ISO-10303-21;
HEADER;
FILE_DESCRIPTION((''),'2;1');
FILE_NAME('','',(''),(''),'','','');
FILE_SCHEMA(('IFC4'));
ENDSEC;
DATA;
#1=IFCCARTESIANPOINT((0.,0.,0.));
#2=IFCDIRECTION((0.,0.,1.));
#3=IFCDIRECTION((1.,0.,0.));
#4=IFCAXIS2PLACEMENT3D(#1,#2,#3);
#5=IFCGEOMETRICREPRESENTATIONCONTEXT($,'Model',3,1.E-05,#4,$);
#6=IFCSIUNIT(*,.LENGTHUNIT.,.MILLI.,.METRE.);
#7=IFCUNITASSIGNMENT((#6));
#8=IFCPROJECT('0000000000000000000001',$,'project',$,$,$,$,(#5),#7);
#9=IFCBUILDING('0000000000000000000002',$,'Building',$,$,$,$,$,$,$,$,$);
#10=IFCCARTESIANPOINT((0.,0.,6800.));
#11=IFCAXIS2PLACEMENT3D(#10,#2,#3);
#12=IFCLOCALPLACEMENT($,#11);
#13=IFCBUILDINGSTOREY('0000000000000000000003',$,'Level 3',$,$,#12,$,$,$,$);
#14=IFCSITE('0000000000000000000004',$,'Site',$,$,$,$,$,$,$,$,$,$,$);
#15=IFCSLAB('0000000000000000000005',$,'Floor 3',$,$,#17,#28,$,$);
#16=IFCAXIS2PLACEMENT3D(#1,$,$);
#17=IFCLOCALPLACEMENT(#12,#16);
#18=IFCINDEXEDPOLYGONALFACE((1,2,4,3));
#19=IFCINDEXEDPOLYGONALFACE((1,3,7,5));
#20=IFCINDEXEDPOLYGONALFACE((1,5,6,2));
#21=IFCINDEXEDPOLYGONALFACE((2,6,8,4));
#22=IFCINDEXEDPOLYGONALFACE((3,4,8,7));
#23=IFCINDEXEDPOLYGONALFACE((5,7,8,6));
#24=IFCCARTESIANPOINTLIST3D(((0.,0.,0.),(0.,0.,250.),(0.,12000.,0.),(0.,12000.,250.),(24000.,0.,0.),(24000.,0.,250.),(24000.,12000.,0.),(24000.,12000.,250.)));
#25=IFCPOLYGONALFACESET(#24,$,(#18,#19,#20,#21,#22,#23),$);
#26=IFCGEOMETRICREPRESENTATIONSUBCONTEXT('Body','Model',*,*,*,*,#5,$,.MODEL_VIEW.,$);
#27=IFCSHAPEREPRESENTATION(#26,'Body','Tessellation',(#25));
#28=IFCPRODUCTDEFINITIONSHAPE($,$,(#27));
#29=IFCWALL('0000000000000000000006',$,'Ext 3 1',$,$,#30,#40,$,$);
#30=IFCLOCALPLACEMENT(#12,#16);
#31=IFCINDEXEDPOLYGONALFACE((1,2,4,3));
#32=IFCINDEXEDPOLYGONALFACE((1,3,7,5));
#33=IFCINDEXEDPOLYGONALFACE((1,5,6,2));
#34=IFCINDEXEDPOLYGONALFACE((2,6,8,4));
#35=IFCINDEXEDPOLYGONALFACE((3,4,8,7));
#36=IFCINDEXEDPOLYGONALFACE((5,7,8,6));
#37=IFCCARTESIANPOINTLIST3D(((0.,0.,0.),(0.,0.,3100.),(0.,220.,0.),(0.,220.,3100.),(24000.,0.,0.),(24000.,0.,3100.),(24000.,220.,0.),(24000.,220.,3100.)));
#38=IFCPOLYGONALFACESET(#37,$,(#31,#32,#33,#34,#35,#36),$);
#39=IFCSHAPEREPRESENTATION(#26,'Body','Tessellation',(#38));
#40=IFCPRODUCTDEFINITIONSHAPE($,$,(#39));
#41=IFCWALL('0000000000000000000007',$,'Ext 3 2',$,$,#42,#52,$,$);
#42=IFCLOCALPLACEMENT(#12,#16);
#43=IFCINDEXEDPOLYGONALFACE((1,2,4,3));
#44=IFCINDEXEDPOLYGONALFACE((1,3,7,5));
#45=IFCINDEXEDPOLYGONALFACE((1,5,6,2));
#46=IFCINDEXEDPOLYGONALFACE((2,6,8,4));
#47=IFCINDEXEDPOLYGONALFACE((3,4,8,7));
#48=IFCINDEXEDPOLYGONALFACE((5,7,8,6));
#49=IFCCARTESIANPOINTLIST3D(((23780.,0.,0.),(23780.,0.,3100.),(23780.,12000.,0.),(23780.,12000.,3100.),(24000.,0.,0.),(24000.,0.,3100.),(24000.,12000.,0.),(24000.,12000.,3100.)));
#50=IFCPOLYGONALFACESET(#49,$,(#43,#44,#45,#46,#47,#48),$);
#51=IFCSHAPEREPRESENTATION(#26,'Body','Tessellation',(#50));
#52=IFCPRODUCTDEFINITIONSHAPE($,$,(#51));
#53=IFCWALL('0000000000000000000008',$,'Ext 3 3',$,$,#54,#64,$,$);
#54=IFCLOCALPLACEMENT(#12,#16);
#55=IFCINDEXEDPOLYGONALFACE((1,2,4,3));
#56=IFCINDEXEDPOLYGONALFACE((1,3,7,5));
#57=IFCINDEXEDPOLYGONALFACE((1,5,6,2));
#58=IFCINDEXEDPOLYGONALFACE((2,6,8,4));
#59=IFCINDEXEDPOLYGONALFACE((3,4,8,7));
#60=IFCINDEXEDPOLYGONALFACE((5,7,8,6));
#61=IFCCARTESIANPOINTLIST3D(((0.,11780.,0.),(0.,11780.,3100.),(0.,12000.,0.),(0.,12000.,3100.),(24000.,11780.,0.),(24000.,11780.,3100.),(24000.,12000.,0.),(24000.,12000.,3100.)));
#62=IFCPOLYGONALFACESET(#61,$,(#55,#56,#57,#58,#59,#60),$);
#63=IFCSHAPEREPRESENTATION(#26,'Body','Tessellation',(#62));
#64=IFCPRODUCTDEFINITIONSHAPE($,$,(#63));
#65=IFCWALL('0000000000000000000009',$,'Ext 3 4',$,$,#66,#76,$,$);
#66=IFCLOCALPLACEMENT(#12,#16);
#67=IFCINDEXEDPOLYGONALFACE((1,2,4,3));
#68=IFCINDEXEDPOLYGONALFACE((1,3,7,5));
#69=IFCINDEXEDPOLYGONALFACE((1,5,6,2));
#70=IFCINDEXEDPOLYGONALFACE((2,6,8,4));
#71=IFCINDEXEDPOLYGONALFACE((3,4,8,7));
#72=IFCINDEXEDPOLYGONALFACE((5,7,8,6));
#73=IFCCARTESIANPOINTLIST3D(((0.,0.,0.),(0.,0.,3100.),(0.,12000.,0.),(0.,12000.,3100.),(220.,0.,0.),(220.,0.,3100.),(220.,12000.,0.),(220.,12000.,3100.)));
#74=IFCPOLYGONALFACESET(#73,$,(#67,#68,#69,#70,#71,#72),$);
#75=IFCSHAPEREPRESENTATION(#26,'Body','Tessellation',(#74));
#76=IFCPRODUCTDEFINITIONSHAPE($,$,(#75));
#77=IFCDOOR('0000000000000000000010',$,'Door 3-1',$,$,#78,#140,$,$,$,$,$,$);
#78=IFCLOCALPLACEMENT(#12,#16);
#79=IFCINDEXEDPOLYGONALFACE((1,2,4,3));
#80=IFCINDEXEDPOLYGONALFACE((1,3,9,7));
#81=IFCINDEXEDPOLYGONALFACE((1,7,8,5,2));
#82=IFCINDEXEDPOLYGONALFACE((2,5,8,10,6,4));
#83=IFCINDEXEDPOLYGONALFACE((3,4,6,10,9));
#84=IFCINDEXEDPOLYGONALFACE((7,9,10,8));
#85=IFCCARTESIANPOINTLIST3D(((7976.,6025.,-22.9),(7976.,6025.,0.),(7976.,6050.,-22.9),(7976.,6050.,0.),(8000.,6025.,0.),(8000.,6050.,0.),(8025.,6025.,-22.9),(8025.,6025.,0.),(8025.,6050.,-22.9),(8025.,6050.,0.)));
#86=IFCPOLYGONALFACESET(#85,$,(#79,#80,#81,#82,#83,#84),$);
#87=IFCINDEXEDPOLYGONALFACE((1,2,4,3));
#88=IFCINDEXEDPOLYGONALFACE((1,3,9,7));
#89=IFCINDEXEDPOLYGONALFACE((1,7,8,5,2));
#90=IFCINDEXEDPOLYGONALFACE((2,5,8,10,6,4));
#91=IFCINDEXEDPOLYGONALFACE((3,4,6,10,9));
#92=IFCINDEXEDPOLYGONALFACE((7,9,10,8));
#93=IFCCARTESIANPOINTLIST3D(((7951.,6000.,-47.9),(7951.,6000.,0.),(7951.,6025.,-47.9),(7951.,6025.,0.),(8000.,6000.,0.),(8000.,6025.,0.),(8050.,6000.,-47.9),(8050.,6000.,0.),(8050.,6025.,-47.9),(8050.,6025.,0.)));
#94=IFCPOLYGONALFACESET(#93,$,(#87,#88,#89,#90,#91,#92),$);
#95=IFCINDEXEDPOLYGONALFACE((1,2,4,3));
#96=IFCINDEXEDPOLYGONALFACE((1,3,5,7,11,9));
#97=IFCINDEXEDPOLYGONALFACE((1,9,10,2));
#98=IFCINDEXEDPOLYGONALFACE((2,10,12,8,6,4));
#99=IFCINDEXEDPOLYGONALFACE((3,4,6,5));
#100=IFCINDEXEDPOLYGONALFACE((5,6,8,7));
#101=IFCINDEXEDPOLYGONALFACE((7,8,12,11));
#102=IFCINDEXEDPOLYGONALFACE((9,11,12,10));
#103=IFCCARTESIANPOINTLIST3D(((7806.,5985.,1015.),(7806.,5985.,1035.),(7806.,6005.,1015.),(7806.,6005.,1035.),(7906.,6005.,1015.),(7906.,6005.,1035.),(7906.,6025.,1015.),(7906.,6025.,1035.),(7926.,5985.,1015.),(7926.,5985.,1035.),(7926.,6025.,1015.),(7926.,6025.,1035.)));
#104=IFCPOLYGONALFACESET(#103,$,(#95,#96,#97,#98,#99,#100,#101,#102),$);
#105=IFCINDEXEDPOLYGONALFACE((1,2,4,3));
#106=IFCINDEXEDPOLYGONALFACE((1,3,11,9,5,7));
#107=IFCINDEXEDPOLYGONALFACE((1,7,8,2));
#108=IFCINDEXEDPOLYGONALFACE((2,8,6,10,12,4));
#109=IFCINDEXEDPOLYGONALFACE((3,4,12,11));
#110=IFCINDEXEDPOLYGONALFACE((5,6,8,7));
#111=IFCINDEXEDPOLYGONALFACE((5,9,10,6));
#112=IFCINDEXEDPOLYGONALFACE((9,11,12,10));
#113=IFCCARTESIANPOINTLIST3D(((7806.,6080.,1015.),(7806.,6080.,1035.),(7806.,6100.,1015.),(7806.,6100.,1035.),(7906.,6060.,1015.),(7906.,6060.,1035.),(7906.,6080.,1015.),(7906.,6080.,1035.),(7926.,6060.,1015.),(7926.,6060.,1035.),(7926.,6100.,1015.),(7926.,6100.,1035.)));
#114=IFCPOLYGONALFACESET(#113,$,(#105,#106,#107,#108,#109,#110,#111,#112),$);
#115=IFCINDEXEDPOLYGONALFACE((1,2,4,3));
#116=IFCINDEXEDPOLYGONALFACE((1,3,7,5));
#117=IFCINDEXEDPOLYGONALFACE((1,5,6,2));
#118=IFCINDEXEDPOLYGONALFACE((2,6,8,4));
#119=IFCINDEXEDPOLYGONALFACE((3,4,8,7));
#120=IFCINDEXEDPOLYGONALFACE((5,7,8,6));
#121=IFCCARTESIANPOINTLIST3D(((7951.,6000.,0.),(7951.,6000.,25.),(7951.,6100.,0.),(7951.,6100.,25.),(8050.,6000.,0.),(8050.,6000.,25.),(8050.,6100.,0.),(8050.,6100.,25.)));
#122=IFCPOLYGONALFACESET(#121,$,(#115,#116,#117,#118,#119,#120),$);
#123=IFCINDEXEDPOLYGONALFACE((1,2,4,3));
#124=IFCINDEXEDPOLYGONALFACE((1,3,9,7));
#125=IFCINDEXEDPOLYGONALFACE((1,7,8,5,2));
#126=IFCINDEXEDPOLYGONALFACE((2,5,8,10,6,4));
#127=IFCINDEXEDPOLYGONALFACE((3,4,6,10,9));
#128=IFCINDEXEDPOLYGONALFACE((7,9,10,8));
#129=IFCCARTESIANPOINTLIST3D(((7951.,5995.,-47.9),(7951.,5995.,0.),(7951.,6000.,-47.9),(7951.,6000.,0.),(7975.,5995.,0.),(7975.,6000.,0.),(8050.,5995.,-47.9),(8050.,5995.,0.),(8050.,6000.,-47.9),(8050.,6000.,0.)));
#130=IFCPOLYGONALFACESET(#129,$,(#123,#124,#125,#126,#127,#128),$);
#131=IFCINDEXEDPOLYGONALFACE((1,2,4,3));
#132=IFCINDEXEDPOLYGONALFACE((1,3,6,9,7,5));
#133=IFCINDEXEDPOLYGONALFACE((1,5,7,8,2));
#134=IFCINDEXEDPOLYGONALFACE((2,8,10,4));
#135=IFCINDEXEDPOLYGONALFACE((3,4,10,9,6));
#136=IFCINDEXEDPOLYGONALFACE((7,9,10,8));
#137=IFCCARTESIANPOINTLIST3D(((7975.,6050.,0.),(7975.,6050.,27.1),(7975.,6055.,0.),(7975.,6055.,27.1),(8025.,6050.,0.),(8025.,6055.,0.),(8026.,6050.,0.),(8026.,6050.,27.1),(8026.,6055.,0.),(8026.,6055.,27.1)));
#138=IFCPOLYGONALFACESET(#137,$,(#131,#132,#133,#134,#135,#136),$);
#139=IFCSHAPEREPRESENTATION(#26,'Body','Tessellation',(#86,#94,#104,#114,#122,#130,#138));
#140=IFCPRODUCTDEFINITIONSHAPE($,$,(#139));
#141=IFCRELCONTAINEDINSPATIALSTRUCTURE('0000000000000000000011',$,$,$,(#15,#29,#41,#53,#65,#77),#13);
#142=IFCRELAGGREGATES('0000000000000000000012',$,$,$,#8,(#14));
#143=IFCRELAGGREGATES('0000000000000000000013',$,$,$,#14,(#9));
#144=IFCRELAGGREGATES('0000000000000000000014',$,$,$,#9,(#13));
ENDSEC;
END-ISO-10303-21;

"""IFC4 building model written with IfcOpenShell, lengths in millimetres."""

from ifc_helpers import new_model, si_unit, frame, origin_with_axes, place, context, subcontext, project, spatial, line, indexed_curve, outline, extrude, element, save


model = new_model("IFC4")

# Units and contexts
model_context = context("Model", 3, precision=1e-05, world=origin_with_axes())
body_context = subcontext(model_context, "Body", "Model", "MODEL_VIEW")
ifc_project = project(units=[si_unit("LENGTHUNIT", "METRE", prefix="MILLI")], contexts=[model_context])

# Site, building, storey
site = spatial("IfcSite", under=ifc_project, Name="Site")
building = spatial("IfcBuilding", under=site, Name="Building")
storey_placement = place(None, frame((0.0, 0.0, 6800.0), z_axis=(0.0, 0.0, 1.0), x_axis=(1.0, 0.0, 0.0)))
storey = spatial("IfcBuildingStorey", under=building, at=storey_placement, Name="Level 3")

# Slab
slab_placement = place(storey_placement, origin_with_axes())
element("IfcSlab", 1, at=slab_placement, inside=storey, Name="Floor 3", context=body_context, shape_type="SweptSolid", body=[
    extrude(outline(indexed_curve([(0.0, 0.0), (24000.0, 0.0), (24000.0, 12000.0), (0.0, 12000.0), (0.0, 0.0)])), None, (0.0, 0.0, 1.0), 250.0),
])

# Walls
wall_1_placement = place(storey_placement, origin_with_axes())
element("IfcWall", 2, at=wall_1_placement, inside=storey, Name="Ext 3 1", context=body_context, shape_type="SweptSolid", body=[
    extrude(outline(indexed_curve([(0.0, 0.0), (0.0, 220.0), (24000.0, 220.0), (24000.0, 0.0), (0.0, 0.0)], self_intersect=False)), origin_with_axes(), (0.0, 0.0, 1.0), 3100.0),
])
wall_2_placement = place(storey_placement, frame((24000.0, 0.0, 0.0), z_axis=(0.0, 0.0, 1.0), x_axis=(0.0, 1.0, 0.0)))
element("IfcWall", 3, at=wall_2_placement, inside=storey, Name="Ext 3 2", context=body_context, shape_type="SweptSolid", body=[
    extrude(outline(indexed_curve([(0.0, 0.0), (0.0, 220.0), (12000.0, 220.0), (12000.0, 0.0), (0.0, 0.0)], self_intersect=False)), origin_with_axes(), (0.0, 0.0, 1.0), 3100.0),
])
wall_3_placement = place(storey_placement, frame((24000.0, 12000.0, 0.0), z_axis=(0.0, 0.0, 1.0), x_axis=(-1.0, 0.0, 0.0)))
element("IfcWall", 4, at=wall_3_placement, inside=storey, Name="Ext 3 3", context=body_context, shape_type="SweptSolid", body=[
    extrude(outline(indexed_curve([(0.0, 0.0), (0.0, 220.0), (24000.0, 220.0), (24000.0, 0.0), (0.0, 0.0)], self_intersect=False)), origin_with_axes(), (0.0, 0.0, 1.0), 3100.0),
])
wall_4_placement = place(storey_placement, frame((0.0, 12000.0, 0.0), z_axis=(0.0, 0.0, 1.0), x_axis=(0.0, -1.0, 0.0)))
element("IfcWall", 5, at=wall_4_placement, inside=storey, Name="Ext 3 4", context=body_context, shape_type="SweptSolid", body=[
    extrude(outline(indexed_curve([(0.0, 0.0), (0.0, 220.0), (12000.0, 220.0), (12000.0, 0.0), (0.0, 0.0)], self_intersect=False)), origin_with_axes(), (0.0, 0.0, 1.0), 3100.0),
])

# Door
door_1_placement = place(storey_placement, frame((8000.0, 6000.0, 0.0), z_axis=(0.0, 0.0, 1.0), x_axis=(1.0, 0.0, 0.0)))
element("IfcDoor", 6, at=door_1_placement, inside=storey, Name="Door 3-1", context=body_context, shape_type="SweptSolid", body=[
    extrude(outline(indexed_curve([(0.0, 0.0), (0.0, 2.1), (1.0, 2.1), (1.0, 0.0), (-24.0, 0.0), (-24.0, -22.9), (25.0, -22.9), (25.0, 0.0)], segments=[line(1, 2, 3, 4, 5, 6, 7, 8, 1)])), frame((0.0, 25.0, 0.0), z_axis=(0.0, -1.0, 0.0), x_axis=(1.0, 0.0, 0.0)), (0.0, 0.0, -1.0), 25.0),
    extrude(outline(indexed_curve([(0.0, 0.0), (0.0, 2.1), (1.0, 2.1), (1.0, 0.0), (-49.0, 0.0), (-49.0, -47.9), (50.0, -47.9), (50.0, 0.0)], segments=[line(1, 2, 3, 4, 5, 6, 7, 8, 1)])), frame((0.0, 0.0, 0.0), z_axis=(0.0, -1.0, 0.0), x_axis=(1.0, 0.0, 0.0)), (0.0, 0.0, -1.0), 25.0),
    extrude(outline(indexed_curve([(0.0, 0.0), (-49.0, 0.0), (-49.0, 35.0), (0.0, 35.0)], segments=[line(1, 2, 3, 4, 1)])), frame((25.0, 25.0, 25.0), z_axis=(0.0, 0.0, 1.0), x_axis=(1.0, 0.0, 0.0)), (0.0, 0.0, 1.0), -47.9),
    extrude(outline(indexed_curve([(0.0, 0.0), (0.0, -40.0), (-120.0, -40.0), (-120.0, -20.0), (-20.0, -20.0), (-20.0, 0.0)], segments=[line(1, 2, 3, 4, 5, 6, 1)])), frame((-74.0, 25.0, 1015.0), z_axis=(0.0, 0.0, 1.0), x_axis=(1.0, 0.0, 0.0)), (0.0, 0.0, 1.0), 20.0),
    extrude(outline(indexed_curve([(0.0, 0.0), (0.0, 40.0), (-120.0, 40.0), (-120.0, 20.0), (-20.0, 20.0), (-20.0, 0.0)], segments=[line(1, 2, 3, 4, 5, 6, 1)])), frame((-74.0, 60.0, 1015.0), z_axis=(0.0, 0.0, 1.0), x_axis=(1.0, 0.0, 0.0)), (0.0, 0.0, 1.0), 20.0),
    extrude(outline(indexed_curve([(0.0, 0.0), (-99.0, 0.0), (-99.0, 100.0), (0.0, 100.0)], segments=[line(1, 2, 3, 4, 1)])), frame((50.0, 0.0, 0.0), z_axis=(0.0, 0.0, 1.0), x_axis=(1.0, 0.0, 0.0)), (0.0, 0.0, 1.0), 25.0),
    extrude(outline(indexed_curve([(0.0, 0.0), (0.0, 27.1), (51.0, 27.1), (51.0, 0.0), (-24.0, 0.0), (-24.0, -47.9), (75.0, -47.9), (75.0, 0.0)], segments=[line(1, 2, 3, 4, 5, 6, 7, 8, 1)])), frame((-25.0, -5.0, 0.0), z_axis=(0.0, -1.0, 0.0), x_axis=(1.0, 0.0, 0.0)), (0.0, 0.0, -1.0), 5.0),
    extrude(outline(indexed_curve([(0.0, 0.0), (0.0, 27.1), (51.0, 27.1), (51.0, 0.0), (1.0, 0.0), (1.0, -22.9), (50.0, -22.9), (50.0, 0.0)], segments=[line(1, 2, 3, 4, 5, 6, 7, 8, 1)])), frame((-25.0, 50.0, 0.0), z_axis=(0.0, -1.0, 0.0), x_axis=(1.0, 0.0, 0.0)), (0.0, 0.0, -1.0), 5.0),
])

save(model, "model.ifc")
